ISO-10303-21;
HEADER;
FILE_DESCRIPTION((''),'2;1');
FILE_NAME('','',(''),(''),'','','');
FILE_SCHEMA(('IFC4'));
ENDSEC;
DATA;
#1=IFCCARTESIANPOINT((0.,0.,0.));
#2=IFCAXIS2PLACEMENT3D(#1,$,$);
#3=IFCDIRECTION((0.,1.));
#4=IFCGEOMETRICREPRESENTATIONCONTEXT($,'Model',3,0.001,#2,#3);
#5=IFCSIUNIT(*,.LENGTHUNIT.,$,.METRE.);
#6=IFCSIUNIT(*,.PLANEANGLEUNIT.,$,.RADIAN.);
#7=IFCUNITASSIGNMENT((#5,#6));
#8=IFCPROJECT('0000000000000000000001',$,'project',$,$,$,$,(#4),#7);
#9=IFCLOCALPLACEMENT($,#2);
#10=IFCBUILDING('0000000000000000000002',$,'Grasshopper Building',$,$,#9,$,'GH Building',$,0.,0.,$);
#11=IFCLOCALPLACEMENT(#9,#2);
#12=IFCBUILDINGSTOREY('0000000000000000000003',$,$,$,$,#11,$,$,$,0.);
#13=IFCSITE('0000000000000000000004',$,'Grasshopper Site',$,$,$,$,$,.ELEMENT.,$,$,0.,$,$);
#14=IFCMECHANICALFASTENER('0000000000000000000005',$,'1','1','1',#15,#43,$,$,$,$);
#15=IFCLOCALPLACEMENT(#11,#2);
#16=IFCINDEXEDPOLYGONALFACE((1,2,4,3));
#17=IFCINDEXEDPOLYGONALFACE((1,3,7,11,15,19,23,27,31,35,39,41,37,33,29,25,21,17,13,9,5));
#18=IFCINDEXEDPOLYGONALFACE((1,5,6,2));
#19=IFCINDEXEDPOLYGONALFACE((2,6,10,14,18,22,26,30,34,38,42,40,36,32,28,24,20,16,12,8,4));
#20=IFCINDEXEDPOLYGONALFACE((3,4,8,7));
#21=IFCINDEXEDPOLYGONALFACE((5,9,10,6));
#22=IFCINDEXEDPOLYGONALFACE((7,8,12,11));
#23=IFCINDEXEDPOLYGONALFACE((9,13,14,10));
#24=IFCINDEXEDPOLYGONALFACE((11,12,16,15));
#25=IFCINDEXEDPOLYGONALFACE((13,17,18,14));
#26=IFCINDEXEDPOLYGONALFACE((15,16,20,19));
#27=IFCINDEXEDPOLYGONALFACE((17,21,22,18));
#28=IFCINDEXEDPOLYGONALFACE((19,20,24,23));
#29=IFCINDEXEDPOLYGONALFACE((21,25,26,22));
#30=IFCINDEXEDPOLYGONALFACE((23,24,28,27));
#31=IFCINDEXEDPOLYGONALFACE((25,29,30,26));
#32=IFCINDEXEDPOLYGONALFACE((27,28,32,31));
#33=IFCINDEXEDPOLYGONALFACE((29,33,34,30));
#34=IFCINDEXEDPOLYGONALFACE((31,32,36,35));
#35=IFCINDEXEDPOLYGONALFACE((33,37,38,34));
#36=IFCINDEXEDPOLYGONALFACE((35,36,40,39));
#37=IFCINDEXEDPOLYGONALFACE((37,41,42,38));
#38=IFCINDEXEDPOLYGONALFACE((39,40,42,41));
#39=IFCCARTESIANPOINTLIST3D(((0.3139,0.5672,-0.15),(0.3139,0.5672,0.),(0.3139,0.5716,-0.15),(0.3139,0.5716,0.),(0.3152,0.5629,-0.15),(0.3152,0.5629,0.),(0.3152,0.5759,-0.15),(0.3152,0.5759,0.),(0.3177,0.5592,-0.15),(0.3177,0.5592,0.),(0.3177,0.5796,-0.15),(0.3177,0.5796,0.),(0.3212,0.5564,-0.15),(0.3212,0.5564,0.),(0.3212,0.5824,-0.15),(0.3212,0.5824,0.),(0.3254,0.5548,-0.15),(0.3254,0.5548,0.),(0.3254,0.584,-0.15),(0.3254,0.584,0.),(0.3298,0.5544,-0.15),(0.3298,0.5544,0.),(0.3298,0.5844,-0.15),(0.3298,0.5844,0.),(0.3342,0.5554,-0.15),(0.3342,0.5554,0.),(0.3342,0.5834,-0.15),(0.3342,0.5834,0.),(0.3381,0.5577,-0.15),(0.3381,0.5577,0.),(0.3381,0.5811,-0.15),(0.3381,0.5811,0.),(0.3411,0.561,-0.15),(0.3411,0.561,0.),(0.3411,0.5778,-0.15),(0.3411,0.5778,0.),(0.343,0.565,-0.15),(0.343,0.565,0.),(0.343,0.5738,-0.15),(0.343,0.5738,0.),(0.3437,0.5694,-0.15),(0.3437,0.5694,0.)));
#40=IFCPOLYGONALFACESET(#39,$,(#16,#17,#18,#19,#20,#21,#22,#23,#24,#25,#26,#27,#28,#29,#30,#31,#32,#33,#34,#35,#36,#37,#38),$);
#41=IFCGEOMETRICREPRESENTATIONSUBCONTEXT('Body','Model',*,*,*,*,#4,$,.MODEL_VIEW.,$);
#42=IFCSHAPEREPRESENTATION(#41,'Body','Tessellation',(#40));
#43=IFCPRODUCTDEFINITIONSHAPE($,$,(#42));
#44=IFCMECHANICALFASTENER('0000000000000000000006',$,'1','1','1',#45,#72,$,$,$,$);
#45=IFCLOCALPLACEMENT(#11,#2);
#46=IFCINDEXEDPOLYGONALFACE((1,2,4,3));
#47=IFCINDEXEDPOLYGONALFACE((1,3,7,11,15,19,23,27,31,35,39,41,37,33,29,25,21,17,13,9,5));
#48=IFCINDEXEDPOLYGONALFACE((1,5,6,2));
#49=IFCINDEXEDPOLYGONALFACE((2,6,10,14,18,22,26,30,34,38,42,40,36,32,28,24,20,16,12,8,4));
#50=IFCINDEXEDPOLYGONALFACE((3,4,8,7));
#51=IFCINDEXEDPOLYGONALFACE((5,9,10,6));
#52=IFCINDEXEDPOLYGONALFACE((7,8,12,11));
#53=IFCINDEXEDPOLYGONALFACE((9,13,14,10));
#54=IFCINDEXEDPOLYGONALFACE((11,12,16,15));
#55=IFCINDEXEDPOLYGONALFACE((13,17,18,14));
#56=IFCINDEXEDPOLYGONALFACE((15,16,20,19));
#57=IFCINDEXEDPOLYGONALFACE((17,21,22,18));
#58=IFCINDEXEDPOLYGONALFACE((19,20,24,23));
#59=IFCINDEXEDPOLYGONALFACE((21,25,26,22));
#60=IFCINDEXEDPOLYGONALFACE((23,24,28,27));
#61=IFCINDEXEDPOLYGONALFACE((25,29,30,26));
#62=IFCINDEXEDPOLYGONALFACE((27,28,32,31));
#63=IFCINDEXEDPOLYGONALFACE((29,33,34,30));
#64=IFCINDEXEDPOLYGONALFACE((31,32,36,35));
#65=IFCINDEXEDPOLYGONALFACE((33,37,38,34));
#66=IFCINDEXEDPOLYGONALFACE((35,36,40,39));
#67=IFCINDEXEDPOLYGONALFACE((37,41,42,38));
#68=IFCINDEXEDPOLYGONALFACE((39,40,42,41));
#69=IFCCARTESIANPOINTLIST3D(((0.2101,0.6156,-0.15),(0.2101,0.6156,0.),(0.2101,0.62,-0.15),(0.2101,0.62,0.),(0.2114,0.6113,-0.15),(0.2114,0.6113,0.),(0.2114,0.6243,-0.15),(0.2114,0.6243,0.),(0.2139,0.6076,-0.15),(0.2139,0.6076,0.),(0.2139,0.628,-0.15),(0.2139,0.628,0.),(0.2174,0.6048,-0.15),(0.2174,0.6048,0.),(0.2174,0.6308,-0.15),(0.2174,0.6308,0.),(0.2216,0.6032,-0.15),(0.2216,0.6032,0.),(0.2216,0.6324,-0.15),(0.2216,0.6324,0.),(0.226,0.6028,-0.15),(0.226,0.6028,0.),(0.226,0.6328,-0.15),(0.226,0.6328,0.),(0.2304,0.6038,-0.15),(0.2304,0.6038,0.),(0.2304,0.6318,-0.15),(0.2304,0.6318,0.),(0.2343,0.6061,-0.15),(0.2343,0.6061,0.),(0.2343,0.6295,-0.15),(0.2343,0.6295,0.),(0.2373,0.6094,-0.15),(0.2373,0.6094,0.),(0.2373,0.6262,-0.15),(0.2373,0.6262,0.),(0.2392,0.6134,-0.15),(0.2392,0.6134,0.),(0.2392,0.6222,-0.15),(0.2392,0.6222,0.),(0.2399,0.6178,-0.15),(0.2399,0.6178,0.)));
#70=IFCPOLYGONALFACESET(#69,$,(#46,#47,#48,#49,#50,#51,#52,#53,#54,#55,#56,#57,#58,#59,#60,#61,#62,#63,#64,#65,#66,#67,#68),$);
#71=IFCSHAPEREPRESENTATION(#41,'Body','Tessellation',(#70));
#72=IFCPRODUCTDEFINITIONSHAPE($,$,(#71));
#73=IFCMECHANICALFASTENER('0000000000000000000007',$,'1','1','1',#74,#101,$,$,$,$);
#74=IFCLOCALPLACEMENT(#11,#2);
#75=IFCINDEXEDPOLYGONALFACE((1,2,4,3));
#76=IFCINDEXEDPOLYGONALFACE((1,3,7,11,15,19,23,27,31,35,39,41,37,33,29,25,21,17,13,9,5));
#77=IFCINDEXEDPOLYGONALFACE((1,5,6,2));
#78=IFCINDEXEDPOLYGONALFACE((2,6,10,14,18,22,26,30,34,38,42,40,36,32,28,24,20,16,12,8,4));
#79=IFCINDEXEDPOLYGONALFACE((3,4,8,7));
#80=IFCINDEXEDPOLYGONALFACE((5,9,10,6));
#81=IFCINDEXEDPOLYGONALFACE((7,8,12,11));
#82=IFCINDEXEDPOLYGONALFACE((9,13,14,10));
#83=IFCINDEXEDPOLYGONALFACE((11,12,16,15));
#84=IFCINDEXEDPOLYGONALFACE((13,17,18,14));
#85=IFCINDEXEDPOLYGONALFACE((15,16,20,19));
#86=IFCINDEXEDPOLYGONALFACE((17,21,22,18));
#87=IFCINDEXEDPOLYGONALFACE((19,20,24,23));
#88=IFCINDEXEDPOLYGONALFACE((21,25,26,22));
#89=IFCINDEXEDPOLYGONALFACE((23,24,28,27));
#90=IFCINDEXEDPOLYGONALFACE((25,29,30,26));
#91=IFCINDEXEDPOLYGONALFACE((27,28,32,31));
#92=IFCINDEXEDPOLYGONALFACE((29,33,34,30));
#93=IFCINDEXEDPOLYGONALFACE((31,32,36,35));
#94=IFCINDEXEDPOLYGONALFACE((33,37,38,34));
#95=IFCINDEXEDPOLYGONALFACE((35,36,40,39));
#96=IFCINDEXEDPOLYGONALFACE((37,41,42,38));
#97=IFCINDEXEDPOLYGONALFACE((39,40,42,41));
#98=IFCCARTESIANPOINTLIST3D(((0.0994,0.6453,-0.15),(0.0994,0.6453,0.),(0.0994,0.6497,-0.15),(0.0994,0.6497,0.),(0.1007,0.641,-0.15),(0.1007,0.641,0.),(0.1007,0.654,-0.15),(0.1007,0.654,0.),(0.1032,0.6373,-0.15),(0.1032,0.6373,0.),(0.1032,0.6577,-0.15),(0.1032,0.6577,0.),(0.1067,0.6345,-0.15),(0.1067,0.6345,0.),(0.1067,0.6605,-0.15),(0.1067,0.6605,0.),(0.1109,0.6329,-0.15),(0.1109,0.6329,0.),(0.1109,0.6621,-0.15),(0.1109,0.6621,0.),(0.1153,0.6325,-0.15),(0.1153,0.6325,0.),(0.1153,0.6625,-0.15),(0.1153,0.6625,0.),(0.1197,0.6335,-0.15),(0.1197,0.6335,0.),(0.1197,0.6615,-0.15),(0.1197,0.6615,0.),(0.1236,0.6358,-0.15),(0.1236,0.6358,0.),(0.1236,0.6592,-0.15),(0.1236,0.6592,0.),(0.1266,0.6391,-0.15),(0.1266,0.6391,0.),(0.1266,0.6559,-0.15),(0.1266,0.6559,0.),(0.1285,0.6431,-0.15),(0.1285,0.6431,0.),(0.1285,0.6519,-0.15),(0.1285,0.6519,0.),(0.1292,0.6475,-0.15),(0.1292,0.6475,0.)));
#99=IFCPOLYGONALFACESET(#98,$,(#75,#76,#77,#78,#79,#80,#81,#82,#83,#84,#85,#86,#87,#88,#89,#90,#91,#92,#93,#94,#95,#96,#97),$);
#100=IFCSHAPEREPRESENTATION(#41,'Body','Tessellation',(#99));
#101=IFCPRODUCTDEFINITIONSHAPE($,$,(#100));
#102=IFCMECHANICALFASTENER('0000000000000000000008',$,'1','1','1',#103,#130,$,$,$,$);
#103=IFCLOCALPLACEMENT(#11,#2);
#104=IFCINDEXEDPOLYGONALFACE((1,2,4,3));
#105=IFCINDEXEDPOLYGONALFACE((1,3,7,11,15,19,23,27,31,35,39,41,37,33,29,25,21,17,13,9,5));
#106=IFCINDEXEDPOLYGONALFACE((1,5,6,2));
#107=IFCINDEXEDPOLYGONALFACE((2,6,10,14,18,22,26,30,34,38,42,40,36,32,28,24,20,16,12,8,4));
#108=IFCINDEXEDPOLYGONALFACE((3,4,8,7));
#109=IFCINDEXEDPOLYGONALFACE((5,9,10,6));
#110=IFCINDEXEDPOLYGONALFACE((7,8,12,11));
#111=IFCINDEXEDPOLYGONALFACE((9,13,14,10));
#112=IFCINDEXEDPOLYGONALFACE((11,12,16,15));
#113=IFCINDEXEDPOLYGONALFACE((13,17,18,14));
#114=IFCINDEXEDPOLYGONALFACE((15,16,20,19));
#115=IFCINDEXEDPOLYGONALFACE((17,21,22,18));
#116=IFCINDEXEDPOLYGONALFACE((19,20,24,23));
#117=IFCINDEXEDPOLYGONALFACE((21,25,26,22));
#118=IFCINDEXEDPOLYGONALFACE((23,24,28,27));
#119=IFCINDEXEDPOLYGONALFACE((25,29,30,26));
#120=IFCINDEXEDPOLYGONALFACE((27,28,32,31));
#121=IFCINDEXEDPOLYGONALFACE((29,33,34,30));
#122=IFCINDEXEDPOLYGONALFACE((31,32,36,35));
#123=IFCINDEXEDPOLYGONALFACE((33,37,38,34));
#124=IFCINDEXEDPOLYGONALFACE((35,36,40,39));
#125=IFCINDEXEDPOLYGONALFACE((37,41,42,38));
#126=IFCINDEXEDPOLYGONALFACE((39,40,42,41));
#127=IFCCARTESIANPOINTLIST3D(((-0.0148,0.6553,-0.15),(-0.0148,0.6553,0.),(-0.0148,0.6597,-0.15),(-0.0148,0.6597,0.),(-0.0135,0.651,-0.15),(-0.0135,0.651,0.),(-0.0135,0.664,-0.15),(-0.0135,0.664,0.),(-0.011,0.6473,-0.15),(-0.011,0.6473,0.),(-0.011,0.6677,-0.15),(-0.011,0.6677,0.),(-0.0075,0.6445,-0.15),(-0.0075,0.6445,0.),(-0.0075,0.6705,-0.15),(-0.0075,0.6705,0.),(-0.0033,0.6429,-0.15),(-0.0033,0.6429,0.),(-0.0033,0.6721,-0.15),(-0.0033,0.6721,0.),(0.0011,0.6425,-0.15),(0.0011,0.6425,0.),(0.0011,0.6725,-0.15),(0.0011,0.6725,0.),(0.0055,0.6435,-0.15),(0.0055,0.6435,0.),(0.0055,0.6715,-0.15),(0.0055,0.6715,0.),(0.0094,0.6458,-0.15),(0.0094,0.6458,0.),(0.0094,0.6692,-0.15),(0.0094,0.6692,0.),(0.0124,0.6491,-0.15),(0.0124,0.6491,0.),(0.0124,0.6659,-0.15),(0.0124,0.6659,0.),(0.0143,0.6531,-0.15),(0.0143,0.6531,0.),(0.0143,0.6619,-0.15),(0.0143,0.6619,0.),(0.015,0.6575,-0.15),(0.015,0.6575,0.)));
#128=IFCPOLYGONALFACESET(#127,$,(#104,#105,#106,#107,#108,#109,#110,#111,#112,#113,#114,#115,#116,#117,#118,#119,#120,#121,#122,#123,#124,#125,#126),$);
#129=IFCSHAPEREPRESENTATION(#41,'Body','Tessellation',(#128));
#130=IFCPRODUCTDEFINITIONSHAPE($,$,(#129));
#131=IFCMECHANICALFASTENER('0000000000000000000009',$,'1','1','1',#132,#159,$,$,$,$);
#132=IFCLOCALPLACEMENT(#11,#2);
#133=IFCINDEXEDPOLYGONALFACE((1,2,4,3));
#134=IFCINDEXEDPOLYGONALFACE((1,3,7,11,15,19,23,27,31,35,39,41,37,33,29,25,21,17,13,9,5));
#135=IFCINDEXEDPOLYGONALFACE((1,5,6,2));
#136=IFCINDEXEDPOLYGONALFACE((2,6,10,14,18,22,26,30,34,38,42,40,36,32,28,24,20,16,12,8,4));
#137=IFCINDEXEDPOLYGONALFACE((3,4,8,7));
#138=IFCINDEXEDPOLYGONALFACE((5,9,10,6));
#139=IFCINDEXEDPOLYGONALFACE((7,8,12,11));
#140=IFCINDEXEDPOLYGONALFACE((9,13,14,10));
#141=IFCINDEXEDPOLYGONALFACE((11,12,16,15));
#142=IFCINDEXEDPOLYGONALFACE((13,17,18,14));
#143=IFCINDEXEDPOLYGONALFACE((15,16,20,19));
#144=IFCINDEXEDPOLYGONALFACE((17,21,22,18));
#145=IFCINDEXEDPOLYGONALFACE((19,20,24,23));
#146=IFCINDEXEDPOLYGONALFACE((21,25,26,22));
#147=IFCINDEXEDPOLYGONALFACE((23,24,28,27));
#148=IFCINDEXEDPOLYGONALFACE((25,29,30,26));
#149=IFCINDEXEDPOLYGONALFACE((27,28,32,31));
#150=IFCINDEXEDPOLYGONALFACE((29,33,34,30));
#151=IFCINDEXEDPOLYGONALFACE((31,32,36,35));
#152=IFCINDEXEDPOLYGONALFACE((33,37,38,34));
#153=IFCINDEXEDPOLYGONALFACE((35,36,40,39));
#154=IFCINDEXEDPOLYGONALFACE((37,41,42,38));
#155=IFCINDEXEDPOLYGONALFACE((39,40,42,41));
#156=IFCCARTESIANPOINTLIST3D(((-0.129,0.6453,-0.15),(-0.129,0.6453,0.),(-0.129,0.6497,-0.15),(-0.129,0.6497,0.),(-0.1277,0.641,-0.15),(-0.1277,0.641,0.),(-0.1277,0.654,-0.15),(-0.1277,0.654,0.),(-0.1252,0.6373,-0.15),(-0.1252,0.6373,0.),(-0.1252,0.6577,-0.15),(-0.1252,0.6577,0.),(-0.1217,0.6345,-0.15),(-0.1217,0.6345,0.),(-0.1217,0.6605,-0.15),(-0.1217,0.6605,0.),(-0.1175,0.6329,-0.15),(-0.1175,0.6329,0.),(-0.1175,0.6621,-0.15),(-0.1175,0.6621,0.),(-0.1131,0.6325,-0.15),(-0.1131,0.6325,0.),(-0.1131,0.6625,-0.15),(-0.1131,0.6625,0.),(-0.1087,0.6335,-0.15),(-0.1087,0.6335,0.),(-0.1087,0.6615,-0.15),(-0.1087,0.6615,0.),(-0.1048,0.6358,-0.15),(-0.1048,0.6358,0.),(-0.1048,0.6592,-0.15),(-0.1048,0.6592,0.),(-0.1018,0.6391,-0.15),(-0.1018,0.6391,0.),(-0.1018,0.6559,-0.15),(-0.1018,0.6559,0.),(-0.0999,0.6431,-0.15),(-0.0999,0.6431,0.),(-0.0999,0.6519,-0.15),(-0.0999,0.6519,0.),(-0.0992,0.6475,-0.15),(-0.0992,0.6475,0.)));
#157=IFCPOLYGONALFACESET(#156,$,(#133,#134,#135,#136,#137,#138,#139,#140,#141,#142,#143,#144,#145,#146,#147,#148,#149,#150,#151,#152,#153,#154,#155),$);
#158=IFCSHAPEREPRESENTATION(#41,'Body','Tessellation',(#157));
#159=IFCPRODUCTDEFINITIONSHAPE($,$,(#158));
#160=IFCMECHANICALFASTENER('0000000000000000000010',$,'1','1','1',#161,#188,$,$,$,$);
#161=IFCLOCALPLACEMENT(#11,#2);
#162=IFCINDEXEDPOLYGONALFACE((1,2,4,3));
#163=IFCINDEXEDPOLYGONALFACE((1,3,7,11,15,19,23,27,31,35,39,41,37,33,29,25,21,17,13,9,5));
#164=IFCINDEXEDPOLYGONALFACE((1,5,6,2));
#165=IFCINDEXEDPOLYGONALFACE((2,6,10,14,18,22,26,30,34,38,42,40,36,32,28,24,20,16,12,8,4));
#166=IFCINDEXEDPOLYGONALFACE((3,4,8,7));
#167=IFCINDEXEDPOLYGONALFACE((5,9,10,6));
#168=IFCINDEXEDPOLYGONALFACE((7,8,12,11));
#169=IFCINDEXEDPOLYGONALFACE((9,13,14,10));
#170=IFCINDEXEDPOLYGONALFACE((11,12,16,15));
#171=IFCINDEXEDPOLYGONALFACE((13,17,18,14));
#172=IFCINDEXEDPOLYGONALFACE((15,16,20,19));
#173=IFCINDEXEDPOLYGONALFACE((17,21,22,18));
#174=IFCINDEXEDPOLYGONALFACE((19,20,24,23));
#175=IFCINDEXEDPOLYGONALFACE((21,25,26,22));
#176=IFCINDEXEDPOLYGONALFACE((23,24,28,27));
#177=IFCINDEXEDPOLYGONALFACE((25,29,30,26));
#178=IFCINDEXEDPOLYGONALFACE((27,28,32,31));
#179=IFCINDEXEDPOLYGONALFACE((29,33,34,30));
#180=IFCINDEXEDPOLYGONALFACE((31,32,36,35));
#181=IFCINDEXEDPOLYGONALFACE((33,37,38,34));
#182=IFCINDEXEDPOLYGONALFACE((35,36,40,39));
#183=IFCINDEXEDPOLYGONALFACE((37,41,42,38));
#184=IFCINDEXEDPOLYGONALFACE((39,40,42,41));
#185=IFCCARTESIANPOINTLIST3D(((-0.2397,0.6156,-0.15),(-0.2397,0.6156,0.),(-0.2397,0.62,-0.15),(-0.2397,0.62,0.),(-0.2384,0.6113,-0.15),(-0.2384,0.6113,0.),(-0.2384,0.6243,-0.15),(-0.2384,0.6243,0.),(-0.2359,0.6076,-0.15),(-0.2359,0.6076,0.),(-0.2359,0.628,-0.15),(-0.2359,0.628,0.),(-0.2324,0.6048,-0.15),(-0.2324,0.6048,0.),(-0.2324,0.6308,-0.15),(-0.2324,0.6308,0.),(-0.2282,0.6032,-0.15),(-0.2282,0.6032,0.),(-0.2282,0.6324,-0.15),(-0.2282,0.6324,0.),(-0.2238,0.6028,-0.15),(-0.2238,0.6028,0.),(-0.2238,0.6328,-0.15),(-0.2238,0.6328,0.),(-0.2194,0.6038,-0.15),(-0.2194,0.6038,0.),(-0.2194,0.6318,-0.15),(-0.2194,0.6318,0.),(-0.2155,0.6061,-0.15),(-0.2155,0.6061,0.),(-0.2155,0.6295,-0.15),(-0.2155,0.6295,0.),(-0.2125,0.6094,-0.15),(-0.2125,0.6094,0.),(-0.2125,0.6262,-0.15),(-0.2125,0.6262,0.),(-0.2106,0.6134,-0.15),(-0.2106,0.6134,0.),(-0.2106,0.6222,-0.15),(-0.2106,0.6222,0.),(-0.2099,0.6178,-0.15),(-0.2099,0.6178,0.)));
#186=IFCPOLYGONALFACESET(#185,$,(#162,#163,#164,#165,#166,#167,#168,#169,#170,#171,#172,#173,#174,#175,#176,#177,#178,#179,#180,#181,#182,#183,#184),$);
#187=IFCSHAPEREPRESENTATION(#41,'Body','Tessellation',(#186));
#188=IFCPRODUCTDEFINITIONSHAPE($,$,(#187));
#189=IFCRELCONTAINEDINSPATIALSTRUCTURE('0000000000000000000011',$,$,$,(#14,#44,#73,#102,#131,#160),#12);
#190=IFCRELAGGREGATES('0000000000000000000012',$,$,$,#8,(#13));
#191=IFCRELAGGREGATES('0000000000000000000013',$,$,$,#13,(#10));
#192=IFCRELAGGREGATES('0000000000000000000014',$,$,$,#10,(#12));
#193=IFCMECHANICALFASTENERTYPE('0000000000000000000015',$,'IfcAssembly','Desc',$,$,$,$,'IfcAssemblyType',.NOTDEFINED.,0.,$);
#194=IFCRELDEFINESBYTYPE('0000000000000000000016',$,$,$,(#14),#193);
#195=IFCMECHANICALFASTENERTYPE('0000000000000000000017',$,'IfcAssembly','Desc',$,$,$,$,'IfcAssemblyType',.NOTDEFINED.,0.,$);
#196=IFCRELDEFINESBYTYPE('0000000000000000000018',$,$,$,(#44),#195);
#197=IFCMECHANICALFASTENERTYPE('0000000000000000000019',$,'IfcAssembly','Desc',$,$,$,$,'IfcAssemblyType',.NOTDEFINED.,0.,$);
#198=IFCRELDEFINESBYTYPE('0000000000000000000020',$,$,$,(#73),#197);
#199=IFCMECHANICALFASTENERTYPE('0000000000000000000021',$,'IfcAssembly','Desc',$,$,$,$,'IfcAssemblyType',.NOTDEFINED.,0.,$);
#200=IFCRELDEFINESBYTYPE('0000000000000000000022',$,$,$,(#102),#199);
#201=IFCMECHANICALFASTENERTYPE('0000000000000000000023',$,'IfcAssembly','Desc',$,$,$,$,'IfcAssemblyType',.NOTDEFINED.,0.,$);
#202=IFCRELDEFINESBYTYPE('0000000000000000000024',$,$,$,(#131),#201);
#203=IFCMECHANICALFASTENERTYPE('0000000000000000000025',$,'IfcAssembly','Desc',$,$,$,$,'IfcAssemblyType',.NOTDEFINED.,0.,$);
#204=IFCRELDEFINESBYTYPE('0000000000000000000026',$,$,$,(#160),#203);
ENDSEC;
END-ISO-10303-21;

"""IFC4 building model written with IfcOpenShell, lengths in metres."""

from ifc_helpers import new_model, si_unit, direction, frame, origin, place, context, subcontext, project, spatial, circle, extrude, source, transform, mapped, type_object, type_shapes, element, save


model = new_model("IFC4")

# Units and contexts
model_context = context("Model", 3, precision=0.001, world=origin(), true_north=direction((0.0, 1.0)))
body_context = subcontext(model_context, "Body", "Model", "MODEL_VIEW")
ifc_project = project(units=[si_unit("LENGTHUNIT", "METRE"), si_unit("PLANEANGLEUNIT", "RADIAN")], contexts=[model_context])

# Site, building, storey
site = spatial("IfcSite", under=ifc_project, Name="Grasshopper Site", CompositionType="ELEMENT", RefElevation=0.0)
building_placement = place(None, origin())
building = spatial("IfcBuilding", under=site, at=building_placement, Name="Grasshopper Building", LongName="GH Building", ElevationOfRefHeight=0.0, ElevationOfTerrain=0.0)
storey_placement = place(building_placement, origin())
storey = spatial("IfcBuildingStorey", under=building, at=storey_placement, Elevation=0.0)

# Mechanical fasteners
mechanical_fastener_type_1 = type_object("IfcMechanicalFastenerType", Name="IfcAssembly", Description="Desc", ElementType="IfcAssemblyType", NominalDiameter=0.0)
shared_shape_1 = source(origin(), body_context, "Body", "SweptSolid", [
    extrude(circle(Radius=0.015), frame((0.3287, 0.5694, 0.0), z_axis=(0.0, 0.0, -1.0), x_axis=(1.0, 0.0, 0.0)), (0.0, 0.0, 1.0), 0.15),
])
type_shapes(mechanical_fastener_type_1, [shared_shape_1])
mechanical_fastener_1_placement = place(storey_placement, origin())
element("IfcMechanicalFastener", 1, at=mechanical_fastener_1_placement, inside=storey, type_object=mechanical_fastener_type_1, Name="1", Description="1", ObjectType="1", context=body_context, shape_type="MappedRepresentation", body=[
    mapped(shared_shape_1, transform((0.0, 0.0, 0.0), scale=1.0)),
])
mechanical_fastener_type_2 = type_object("IfcMechanicalFastenerType", Name="IfcAssembly", Description="Desc", ElementType="IfcAssemblyType", NominalDiameter=0.0)
shared_shape_2 = source(origin(), body_context, "Body", "SweptSolid", [
    extrude(circle(Radius=0.015), frame((0.2249, 0.6178, 0.0), z_axis=(0.0, 0.0, -1.0), x_axis=(1.0, 0.0, 0.0)), (0.0, 0.0, 1.0), 0.15),
])
type_shapes(mechanical_fastener_type_2, [shared_shape_2])
mechanical_fastener_2_placement = place(storey_placement, origin())
element("IfcMechanicalFastener", 2, at=mechanical_fastener_2_placement, inside=storey, type_object=mechanical_fastener_type_2, Name="1", Description="1", ObjectType="1", context=body_context, shape_type="MappedRepresentation", body=[
    mapped(shared_shape_2, transform((0.0, 0.0, 0.0), scale=1.0)),
])
mechanical_fastener_type_3 = type_object("IfcMechanicalFastenerType", Name="IfcAssembly", Description="Desc", ElementType="IfcAssemblyType", NominalDiameter=0.0)
shared_shape_3 = source(origin(), body_context, "Body", "SweptSolid", [
    extrude(circle(Radius=0.015), frame((0.1142, 0.6475, 0.0), z_axis=(0.0, 0.0, -1.0), x_axis=(1.0, 0.0, 0.0)), (0.0, 0.0, 1.0), 0.15),
])
type_shapes(mechanical_fastener_type_3, [shared_shape_3])
mechanical_fastener_3_placement = place(storey_placement, origin())
element("IfcMechanicalFastener", 3, at=mechanical_fastener_3_placement, inside=storey, type_object=mechanical_fastener_type_3, Name="1", Description="1", ObjectType="1", context=body_context, shape_type="MappedRepresentation", body=[
    mapped(shared_shape_3, transform((0.0, 0.0, 0.0), scale=1.0)),
])
mechanical_fastener_type_4 = type_object("IfcMechanicalFastenerType", Name="IfcAssembly", Description="Desc", ElementType="IfcAssemblyType", NominalDiameter=0.0)
shared_shape_4 = source(origin(), body_context, "Body", "SweptSolid", [
    extrude(circle(Radius=0.015), frame((0.0, 0.6575, 0.0), z_axis=(0.0, 0.0, -1.0), x_axis=(1.0, 0.0, 0.0)), (0.0, 0.0, 1.0), 0.15),
])
type_shapes(mechanical_fastener_type_4, [shared_shape_4])
mechanical_fastener_4_placement = place(storey_placement, origin())
element("IfcMechanicalFastener", 4, at=mechanical_fastener_4_placement, inside=storey, type_object=mechanical_fastener_type_4, Name="1", Description="1", ObjectType="1", context=body_context, shape_type="MappedRepresentation", body=[
    mapped(shared_shape_4, transform((0.0, 0.0, 0.0), scale=1.0)),
])
mechanical_fastener_type_5 = type_object("IfcMechanicalFastenerType", Name="IfcAssembly", Description="Desc", ElementType="IfcAssemblyType", NominalDiameter=0.0)
shared_shape_5 = source(origin(), body_context, "Body", "SweptSolid", [
    extrude(circle(Radius=0.015), frame((-0.1142, 0.6475, 0.0), z_axis=(0.0, 0.0, -1.0), x_axis=(1.0, 0.0, 0.0)), (0.0, 0.0, 1.0), 0.15),
])
type_shapes(mechanical_fastener_type_5, [shared_shape_5])
mechanical_fastener_5_placement = place(storey_placement, origin())
element("IfcMechanicalFastener", 5, at=mechanical_fastener_5_placement, inside=storey, type_object=mechanical_fastener_type_5, Name="1", Description="1", ObjectType="1", context=body_context, shape_type="MappedRepresentation", body=[
    mapped(shared_shape_5, transform((0.0, 0.0, 0.0), scale=1.0)),
])
mechanical_fastener_type_6 = type_object("IfcMechanicalFastenerType", Name="IfcAssembly", Description="Desc", ElementType="IfcAssemblyType", NominalDiameter=0.0)
shared_shape_6 = source(origin(), body_context, "Body", "SweptSolid", [
    extrude(circle(Radius=0.015), frame((-0.2249, 0.6178, 0.0), z_axis=(0.0, 0.0, -1.0), x_axis=(1.0, 0.0, 0.0)), (0.0, 0.0, 1.0), 0.15),
])
type_shapes(mechanical_fastener_type_6, [shared_shape_6])
mechanical_fastener_6_placement = place(storey_placement, origin())
element("IfcMechanicalFastener", 6, at=mechanical_fastener_6_placement, inside=storey, type_object=mechanical_fastener_type_6, Name="1", Description="1", ObjectType="1", context=body_context, shape_type="MappedRepresentation", body=[
    mapped(shared_shape_6, transform((0.0, 0.0, 0.0), scale=1.0)),
])

save(model, "model.ifc")
